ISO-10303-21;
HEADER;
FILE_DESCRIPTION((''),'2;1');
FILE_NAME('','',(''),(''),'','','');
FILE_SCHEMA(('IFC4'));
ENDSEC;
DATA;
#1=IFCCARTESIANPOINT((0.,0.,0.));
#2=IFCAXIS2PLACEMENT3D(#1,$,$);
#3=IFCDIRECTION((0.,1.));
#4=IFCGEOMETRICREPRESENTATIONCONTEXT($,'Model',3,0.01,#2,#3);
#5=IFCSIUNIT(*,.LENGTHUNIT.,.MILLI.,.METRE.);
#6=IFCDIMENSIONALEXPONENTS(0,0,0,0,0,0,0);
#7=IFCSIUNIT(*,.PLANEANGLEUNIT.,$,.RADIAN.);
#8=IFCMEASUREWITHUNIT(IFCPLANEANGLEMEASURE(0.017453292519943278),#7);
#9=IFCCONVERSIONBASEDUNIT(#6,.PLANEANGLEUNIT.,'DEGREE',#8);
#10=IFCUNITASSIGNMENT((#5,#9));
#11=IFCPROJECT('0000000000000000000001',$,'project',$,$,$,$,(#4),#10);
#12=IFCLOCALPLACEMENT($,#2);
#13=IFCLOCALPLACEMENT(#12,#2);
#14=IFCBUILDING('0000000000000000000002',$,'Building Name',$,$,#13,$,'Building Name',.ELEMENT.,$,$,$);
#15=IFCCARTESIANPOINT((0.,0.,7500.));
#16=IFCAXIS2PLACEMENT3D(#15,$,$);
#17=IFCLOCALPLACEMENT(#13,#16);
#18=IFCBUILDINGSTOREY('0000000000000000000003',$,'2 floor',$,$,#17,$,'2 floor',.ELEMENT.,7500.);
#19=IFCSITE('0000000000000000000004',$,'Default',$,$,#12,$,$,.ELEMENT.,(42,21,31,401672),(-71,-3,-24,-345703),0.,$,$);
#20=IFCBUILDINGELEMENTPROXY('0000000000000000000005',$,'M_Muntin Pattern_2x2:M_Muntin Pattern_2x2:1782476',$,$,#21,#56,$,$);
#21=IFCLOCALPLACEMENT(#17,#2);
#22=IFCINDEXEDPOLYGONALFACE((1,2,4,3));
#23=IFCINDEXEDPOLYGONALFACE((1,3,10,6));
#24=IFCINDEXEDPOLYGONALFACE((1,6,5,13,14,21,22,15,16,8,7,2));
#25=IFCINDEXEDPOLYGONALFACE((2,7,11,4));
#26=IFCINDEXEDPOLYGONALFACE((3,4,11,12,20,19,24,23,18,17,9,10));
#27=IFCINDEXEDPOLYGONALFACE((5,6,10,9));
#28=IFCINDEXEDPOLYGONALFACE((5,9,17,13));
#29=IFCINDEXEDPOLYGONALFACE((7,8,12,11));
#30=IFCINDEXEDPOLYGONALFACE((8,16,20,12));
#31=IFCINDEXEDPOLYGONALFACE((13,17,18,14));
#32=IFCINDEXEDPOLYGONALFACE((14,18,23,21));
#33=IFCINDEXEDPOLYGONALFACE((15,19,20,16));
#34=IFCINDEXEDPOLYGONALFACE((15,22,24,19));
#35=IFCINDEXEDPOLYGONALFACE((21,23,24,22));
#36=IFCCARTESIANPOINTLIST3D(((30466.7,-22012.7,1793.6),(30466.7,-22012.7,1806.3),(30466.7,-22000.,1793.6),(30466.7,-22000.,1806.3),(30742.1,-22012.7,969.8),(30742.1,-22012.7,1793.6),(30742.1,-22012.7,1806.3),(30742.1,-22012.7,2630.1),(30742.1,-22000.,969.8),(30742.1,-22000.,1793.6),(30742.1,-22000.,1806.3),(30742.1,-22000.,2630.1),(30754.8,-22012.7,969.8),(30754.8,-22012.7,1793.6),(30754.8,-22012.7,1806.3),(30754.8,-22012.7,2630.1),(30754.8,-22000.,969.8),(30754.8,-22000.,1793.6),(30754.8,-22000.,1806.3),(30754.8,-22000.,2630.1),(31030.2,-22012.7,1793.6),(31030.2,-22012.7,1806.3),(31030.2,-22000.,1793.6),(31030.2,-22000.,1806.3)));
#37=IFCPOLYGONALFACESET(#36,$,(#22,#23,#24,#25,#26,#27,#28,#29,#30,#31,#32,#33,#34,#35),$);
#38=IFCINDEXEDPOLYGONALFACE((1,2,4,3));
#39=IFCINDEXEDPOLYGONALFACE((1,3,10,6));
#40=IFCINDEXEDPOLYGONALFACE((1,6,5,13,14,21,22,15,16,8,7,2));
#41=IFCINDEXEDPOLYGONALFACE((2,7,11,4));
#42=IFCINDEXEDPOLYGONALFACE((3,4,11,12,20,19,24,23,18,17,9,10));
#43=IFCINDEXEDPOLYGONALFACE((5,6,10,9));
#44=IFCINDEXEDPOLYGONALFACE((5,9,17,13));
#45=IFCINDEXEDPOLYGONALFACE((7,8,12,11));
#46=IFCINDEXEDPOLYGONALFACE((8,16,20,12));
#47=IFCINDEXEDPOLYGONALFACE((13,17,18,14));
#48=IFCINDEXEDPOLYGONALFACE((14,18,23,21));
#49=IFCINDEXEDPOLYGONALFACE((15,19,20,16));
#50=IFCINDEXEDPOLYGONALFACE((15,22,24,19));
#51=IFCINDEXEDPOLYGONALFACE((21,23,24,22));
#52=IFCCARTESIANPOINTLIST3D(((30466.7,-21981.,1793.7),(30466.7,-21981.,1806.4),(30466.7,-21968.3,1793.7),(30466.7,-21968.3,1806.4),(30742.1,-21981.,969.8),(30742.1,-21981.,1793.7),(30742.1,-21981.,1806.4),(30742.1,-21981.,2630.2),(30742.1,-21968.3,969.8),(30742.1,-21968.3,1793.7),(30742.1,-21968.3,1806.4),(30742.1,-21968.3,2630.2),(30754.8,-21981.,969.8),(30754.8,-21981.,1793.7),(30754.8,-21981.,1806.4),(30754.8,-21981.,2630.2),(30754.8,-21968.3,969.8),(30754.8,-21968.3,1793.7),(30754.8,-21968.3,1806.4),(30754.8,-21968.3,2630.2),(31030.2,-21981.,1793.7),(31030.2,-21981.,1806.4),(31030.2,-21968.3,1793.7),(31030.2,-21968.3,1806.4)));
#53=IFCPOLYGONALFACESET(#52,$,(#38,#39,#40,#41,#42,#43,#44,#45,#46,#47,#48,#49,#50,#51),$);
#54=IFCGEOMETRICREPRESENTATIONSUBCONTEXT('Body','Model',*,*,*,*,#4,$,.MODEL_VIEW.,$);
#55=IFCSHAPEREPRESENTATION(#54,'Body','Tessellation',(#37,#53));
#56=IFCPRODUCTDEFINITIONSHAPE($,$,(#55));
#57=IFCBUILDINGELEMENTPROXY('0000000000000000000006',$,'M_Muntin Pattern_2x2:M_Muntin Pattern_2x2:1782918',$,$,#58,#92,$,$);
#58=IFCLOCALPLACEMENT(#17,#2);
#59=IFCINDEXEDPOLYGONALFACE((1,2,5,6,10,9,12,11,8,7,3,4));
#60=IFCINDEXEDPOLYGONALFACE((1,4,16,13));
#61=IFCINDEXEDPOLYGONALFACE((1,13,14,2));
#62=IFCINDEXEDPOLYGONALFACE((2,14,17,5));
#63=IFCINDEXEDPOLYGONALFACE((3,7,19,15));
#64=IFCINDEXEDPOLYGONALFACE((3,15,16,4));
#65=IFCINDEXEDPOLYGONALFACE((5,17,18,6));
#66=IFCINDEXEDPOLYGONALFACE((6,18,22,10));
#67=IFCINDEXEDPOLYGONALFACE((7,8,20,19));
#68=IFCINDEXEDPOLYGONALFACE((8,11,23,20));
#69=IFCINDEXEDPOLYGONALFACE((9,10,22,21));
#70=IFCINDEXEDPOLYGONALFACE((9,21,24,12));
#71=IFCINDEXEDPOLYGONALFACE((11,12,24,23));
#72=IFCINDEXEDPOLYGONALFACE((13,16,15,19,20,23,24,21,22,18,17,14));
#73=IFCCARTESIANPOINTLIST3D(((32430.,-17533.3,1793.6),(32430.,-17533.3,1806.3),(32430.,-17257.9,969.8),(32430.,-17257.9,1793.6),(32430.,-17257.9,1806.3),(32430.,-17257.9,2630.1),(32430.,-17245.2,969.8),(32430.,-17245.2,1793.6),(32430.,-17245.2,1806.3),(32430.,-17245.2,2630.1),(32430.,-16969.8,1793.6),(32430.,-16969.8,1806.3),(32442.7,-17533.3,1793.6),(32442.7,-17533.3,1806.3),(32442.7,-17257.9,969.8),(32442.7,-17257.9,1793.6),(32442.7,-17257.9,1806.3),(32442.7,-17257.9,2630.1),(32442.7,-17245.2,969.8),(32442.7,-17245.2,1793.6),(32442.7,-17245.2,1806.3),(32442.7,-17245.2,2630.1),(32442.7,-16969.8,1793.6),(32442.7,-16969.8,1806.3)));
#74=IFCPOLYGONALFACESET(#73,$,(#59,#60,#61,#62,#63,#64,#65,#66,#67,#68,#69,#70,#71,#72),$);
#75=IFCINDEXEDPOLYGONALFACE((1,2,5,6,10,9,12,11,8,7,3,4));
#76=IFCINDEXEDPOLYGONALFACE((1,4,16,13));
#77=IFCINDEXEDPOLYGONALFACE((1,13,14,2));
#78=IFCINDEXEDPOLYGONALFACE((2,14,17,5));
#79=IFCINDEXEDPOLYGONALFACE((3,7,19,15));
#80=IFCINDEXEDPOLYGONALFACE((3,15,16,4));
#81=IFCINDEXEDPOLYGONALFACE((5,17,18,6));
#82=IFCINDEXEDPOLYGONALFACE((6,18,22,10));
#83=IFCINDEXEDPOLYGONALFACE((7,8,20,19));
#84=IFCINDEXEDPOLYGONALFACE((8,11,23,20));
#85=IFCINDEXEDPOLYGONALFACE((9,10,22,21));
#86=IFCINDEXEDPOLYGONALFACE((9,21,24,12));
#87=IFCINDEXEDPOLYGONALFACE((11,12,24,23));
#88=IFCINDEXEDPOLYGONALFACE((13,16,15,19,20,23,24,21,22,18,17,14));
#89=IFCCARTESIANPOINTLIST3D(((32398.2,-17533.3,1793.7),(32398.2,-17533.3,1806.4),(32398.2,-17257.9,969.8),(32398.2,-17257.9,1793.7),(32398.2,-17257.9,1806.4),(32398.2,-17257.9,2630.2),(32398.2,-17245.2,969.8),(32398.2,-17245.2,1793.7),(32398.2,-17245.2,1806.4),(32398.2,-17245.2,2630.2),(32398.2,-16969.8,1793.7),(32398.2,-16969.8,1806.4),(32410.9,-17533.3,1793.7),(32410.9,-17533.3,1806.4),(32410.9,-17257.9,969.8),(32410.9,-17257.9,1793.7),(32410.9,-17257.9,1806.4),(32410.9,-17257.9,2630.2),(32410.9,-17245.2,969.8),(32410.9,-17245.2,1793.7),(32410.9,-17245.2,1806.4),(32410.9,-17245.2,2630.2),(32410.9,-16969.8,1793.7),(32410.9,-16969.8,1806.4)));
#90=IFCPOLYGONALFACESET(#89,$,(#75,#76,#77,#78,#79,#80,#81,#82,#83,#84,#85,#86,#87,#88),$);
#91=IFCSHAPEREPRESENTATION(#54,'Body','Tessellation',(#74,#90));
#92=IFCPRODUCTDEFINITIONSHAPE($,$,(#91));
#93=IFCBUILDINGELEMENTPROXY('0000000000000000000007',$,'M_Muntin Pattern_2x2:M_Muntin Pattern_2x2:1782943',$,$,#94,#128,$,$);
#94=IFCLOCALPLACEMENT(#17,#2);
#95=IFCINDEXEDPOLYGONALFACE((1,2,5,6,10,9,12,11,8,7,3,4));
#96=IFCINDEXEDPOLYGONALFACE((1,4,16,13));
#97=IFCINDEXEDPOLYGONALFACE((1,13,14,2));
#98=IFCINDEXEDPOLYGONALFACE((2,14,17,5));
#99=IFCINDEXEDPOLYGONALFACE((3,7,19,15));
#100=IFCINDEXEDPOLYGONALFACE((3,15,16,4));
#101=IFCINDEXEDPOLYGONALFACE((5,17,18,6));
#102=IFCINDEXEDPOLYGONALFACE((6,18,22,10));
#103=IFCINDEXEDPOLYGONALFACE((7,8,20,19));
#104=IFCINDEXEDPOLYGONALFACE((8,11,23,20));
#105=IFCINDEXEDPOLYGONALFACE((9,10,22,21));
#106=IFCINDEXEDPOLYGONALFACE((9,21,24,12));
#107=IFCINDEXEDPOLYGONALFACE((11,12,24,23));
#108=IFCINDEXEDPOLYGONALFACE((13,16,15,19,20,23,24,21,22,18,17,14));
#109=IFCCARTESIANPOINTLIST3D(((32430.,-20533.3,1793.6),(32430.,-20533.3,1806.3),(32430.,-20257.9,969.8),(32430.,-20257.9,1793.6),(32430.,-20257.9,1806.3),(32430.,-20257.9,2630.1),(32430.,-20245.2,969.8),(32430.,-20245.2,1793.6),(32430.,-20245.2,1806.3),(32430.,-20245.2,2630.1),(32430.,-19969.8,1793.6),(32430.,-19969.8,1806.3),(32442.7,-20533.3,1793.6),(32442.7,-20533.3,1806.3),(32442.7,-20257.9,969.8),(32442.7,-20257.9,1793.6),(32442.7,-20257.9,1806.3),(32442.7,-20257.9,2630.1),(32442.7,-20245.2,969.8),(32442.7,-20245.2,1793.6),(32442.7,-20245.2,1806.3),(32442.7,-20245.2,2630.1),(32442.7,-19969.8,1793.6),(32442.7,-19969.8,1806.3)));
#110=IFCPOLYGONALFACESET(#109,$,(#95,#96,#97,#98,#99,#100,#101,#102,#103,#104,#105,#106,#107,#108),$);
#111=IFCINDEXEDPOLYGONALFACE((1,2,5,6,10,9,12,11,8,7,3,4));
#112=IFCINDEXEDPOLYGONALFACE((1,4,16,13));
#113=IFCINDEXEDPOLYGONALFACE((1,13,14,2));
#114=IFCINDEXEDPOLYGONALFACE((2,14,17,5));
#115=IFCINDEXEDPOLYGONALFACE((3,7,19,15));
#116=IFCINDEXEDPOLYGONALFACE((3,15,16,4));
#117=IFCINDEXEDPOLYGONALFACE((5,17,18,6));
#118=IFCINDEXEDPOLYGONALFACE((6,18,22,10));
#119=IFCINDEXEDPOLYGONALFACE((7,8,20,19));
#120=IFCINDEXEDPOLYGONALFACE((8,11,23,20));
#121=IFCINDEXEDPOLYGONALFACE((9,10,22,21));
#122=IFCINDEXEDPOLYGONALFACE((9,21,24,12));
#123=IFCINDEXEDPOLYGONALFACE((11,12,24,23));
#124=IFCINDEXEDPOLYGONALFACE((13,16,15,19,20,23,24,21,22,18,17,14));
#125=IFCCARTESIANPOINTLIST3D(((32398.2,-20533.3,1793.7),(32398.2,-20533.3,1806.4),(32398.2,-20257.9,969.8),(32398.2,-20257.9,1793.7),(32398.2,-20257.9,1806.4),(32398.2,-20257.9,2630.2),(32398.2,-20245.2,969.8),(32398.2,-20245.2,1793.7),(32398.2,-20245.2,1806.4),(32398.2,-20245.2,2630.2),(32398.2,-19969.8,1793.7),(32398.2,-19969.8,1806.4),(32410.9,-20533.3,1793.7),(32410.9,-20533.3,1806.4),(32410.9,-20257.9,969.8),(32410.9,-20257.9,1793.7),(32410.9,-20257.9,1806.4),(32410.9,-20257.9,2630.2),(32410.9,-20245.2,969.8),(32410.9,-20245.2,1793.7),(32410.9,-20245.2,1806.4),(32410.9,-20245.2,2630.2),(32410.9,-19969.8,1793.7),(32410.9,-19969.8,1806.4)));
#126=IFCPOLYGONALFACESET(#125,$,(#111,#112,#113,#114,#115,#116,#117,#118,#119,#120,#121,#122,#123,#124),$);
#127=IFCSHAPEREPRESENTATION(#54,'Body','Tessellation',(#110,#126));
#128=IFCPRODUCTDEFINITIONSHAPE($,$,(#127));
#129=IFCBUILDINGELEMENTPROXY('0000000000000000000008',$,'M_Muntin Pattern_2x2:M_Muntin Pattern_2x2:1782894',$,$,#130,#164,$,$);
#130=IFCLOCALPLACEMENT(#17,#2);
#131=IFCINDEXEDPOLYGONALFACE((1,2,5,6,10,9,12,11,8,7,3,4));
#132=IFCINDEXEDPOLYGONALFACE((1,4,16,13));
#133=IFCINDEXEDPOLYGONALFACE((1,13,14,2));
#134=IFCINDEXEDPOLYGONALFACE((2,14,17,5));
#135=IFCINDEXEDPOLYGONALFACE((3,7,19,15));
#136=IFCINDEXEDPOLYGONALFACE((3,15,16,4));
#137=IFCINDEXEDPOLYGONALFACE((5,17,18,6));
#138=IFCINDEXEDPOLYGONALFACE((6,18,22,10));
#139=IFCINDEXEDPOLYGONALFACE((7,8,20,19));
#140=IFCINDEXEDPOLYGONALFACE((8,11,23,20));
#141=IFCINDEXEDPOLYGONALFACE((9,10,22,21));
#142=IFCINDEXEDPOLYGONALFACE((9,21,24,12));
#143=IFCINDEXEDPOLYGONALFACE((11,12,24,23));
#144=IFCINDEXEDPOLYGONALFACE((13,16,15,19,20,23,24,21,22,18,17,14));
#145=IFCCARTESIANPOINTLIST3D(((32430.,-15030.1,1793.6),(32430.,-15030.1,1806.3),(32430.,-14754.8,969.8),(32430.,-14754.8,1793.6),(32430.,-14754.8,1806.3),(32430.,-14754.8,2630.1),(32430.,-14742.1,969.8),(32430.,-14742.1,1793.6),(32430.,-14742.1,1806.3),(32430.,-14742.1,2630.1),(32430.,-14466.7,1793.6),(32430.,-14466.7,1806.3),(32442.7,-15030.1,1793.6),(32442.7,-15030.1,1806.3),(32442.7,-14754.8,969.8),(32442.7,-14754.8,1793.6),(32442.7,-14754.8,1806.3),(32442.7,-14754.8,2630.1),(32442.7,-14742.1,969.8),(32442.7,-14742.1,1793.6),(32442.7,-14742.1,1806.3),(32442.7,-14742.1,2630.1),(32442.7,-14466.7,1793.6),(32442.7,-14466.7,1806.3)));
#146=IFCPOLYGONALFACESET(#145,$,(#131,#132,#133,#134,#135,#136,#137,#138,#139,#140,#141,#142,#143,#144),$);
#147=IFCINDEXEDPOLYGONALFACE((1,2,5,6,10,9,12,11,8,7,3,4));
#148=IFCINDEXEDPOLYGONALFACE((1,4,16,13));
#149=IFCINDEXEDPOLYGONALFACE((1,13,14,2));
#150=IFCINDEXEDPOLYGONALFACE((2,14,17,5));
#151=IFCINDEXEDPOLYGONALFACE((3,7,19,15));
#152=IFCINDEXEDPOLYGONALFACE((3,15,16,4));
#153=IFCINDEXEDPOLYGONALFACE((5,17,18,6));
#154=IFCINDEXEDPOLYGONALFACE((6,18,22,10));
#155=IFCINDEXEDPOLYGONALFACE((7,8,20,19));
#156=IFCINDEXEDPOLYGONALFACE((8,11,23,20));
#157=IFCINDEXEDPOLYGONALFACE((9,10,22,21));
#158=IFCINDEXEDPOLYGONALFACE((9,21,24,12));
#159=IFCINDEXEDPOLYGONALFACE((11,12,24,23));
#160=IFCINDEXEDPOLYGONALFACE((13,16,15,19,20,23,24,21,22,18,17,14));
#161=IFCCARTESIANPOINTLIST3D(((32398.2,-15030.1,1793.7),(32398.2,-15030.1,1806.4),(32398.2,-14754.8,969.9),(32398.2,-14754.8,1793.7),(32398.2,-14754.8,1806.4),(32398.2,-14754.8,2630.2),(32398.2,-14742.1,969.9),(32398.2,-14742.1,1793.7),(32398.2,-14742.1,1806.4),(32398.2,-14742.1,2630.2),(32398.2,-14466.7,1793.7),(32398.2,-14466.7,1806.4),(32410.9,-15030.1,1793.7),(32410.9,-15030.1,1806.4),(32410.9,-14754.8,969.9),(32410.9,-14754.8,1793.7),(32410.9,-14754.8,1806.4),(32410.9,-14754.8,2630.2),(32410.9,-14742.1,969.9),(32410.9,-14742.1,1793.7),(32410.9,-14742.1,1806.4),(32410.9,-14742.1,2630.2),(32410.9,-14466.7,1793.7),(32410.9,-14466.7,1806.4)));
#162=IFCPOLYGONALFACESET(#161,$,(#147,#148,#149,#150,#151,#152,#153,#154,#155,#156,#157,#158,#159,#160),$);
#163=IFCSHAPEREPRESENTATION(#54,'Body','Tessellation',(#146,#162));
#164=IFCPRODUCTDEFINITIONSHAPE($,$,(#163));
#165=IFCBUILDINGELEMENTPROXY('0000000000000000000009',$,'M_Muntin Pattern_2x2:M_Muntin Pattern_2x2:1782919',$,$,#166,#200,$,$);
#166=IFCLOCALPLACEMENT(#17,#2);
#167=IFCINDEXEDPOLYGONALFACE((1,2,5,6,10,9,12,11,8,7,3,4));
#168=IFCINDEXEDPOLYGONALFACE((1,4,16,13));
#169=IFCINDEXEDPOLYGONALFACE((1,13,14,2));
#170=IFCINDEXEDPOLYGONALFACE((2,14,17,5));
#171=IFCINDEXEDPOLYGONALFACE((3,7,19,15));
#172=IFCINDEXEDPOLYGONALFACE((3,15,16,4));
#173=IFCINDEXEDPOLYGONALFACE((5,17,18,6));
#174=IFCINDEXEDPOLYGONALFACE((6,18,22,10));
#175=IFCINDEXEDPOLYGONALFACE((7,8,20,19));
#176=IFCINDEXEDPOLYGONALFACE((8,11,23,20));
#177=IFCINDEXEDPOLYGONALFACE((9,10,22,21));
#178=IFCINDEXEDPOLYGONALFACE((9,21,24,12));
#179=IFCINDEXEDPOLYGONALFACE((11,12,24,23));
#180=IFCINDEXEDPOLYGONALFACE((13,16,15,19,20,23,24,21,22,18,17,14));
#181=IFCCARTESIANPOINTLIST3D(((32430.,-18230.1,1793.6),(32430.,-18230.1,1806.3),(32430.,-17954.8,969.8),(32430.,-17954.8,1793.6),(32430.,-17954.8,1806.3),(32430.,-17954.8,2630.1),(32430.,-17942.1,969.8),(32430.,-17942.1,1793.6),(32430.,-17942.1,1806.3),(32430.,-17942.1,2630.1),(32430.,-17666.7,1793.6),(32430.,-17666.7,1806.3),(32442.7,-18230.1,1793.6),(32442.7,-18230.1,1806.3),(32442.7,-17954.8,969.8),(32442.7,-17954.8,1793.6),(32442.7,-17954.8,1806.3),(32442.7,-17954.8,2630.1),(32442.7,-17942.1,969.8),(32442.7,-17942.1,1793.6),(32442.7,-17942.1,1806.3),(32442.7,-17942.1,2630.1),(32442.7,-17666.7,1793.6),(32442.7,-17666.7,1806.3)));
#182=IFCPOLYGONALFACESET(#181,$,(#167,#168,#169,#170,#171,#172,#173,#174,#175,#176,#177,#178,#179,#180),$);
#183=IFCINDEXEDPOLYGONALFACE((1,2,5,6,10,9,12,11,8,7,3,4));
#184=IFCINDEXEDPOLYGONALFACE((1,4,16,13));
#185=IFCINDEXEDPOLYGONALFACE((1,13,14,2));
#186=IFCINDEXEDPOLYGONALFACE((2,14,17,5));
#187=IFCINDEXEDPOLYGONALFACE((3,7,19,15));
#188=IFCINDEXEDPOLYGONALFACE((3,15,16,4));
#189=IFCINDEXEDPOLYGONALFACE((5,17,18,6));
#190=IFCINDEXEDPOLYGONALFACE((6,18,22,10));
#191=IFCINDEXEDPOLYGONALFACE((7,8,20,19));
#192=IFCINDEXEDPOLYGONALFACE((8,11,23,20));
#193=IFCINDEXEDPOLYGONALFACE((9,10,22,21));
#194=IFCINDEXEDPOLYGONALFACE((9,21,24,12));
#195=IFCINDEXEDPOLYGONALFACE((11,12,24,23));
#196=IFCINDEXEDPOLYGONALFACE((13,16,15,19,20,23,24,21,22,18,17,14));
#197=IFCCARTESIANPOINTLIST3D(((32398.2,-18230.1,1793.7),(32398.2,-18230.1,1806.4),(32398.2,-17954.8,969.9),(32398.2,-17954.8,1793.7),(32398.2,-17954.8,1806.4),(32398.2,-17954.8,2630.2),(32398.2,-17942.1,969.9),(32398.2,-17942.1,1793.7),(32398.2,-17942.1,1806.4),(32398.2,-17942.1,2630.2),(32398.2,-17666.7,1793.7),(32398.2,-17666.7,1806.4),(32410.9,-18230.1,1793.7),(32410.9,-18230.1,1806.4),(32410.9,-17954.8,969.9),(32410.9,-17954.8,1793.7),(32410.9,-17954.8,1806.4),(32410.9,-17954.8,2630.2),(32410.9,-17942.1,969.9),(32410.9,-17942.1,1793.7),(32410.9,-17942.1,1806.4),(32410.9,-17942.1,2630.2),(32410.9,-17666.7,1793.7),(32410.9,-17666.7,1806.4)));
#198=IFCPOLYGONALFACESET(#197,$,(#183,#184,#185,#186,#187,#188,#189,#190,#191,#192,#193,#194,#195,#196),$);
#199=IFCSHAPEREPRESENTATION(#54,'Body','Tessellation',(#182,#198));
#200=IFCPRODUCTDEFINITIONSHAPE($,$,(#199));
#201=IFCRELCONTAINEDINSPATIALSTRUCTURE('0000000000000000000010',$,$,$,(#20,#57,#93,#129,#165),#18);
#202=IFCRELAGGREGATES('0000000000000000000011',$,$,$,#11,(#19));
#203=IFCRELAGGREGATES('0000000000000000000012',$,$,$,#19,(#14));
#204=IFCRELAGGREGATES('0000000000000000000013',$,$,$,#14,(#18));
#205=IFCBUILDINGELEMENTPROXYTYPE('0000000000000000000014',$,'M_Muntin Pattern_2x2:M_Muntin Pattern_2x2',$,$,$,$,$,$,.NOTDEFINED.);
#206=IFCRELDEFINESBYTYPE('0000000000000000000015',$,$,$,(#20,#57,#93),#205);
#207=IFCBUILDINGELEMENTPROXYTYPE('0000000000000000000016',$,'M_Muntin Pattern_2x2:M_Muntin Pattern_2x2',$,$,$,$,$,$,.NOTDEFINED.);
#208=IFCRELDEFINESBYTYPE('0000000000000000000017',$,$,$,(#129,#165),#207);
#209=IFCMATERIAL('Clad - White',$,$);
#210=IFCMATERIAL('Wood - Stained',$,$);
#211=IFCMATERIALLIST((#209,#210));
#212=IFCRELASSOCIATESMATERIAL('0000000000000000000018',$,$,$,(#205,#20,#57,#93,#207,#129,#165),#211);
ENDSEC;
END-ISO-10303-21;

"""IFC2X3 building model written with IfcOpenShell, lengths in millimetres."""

from ifc_helpers import new_model, entity, si_unit, converted_unit, direction, frame, origin, place, context, subcontext, project, spatial, polyline, outline, extrude, source, transform, mapped, material, material_list, type_object, type_shapes, element, save


model = new_model("IFC2X3")

# Units and contexts
model_context = context("Model", 3, precision=0.01, world=origin(), true_north=direction((0.0, 1.0)))
body_context = subcontext(model_context, "Body", "Model", "MODEL_VIEW")
ifc_project = project(units=[si_unit("LENGTHUNIT", "METRE", prefix="MILLI"), converted_unit("PLANEANGLEUNIT", "DEGREE", entity("IfcPlaneAngleMeasure", 0.017453292519943278), si_unit("PLANEANGLEUNIT", "RADIAN"), dimensions=[0, 0, 0, 0, 0, 0, 0])], contexts=[model_context])

# Site, building, storey
site_placement = place(None, origin())
site = spatial("IfcSite", under=ifc_project, at=site_placement, Name="Default", CompositionType="ELEMENT", RefLatitude=(42, 21, 31, 401672), RefLongitude=(-71, -3, -24, -345703), RefElevation=0.0)
building_placement = place(site_placement, origin())
building = spatial("IfcBuilding", under=site, at=building_placement, Name="Building Name", LongName="Building Name", CompositionType="ELEMENT")
storey_placement = place(building_placement, frame((0.0, 0.0, 7500.0)))
storey = spatial("IfcBuildingStorey", under=building, at=storey_placement, Name="2 floor", LongName="2 floor", CompositionType="ELEMENT", Elevation=7500.0)

# Building element proxies
ifc_material_1 = material(Name="Clad - White")
ifc_material_2 = material(Name="Wood - Stained")
ifc_material_list = material_list([ifc_material_1, ifc_material_2])
building_element_proxy_type_1 = type_object("IfcBuildingElementProxyType", Name="M_Muntin Pattern_2x2:M_Muntin Pattern_2x2", PredefinedType="NOTDEFINED", material=ifc_material_list)
shared_shape_1 = source(origin(), body_context, "Body", "SweptSolid", [
    extrude(outline(polyline([(6.4, -6.4), (830.1, -6.4), (830.1, 6.3), (6.4, 6.3), (6.4, 281.7), (-6.3, 281.7), (-6.3, 6.3), (-830.2, 6.3), (-830.2, -6.4), (-6.3, -6.4), (-6.3, -281.7), (6.4, -281.7), (6.4, -6.4)])), frame((0.0, 9.5, 830.1), z_axis=(0.0, 1.0, 0.0), x_axis=(0.0, 0.0, 1.0)), (0.0, 0.0, 1.0), 12.7),
    extrude(outline(polyline([(6.4, -6.4), (830.2, -6.4), (830.2, 6.3), (6.4, 6.3), (6.4, 281.7), (-6.3, 281.7), (-6.3, 6.3), (-830.2, 6.3), (-830.2, -6.4), (-6.3, -6.4), (-6.3, -281.7), (6.4, -281.7), (6.4, -6.4)])), frame((0.0, -22.2, 830.2), z_axis=(0.0, 1.0, 0.0), x_axis=(0.0, 0.0, 1.0)), (0.0, 0.0, 1.0), 12.7),
])
type_shapes(building_element_proxy_type_1, [shared_shape_1])
for number, where, z_axis, x_axis, name in (
    (1, (30748.4, -21990.5, 969.8), (0.0, 0.0, 1.0), (-1.0, 0.0, 0.0), "M_Muntin Pattern_2x2:M_Muntin Pattern_2x2:1782476"),
    (2, (32420.5, -17251.6, 969.8), (0.0, 0.0, 1.0), (0.0, -1.0, 0.0), "M_Muntin Pattern_2x2:M_Muntin Pattern_2x2:1782918"),
    (3, (32420.5, -20251.6, 969.8), (0.0, 0.0, 1.0), (0.0, -1.0, 0.0), "M_Muntin Pattern_2x2:M_Muntin Pattern_2x2:1782943"),
):
    element("IfcBuildingElementProxy", number, at=place(storey_placement, frame(where, z_axis=z_axis, x_axis=x_axis)), inside=storey, type_object=building_element_proxy_type_1, material=ifc_material_list, Name=name, context=body_context, shape_type="MappedRepresentation", body=[
        mapped(shared_shape_1, transform((0.0, 0.0, 0.0), scale=1.0)),
    ])
building_element_proxy_type_2 = type_object("IfcBuildingElementProxyType", Name="M_Muntin Pattern_2x2:M_Muntin Pattern_2x2", PredefinedType="NOTDEFINED", material=ifc_material_list)
shared_shape_2 = source(origin(), body_context, "Body", "SweptSolid", [
    extrude(outline(polyline([(6.4, -6.4), (830.1, -6.4), (830.1, 6.3), (6.4, 6.3), (6.4, 281.7), (-6.3, 281.7), (-6.3, 6.3), (-830.2, 6.3), (-830.2, -6.4), (-6.3, -6.4), (-6.3, -281.7), (6.4, -281.7), (6.4, -6.4)])), frame((0.0, -22.2, 830.1), z_axis=(0.0, 1.0, 0.0), x_axis=(0.0, 0.0, 1.0)), (0.0, 0.0, 1.0), 12.7),
    extrude(outline(polyline([(6.4, -6.4), (830.2, -6.4), (830.2, 6.3), (6.4, 6.3), (6.4, 281.7), (-6.3, 281.7), (-6.3, 6.3), (-830.2, 6.3), (-830.2, -6.4), (-6.3, -6.4), (-6.3, -281.7), (6.4, -281.7), (6.4, -6.4)])), frame((0.0, 9.5, 830.2), z_axis=(0.0, 1.0, 0.0), x_axis=(0.0, 0.0, 1.0)), (0.0, 0.0, 1.0), 12.7),
])
type_shapes(building_element_proxy_type_2, [shared_shape_2])
for number, where, z_axis, x_axis, name in (
    (4, (32420.5, -14748.4, 969.9), (0.0, 0.0, 1.0), (0.0, 1.0, 0.0), "M_Muntin Pattern_2x2:M_Muntin Pattern_2x2:1782894"),
    (5, (32420.5, -17948.4, 969.9), (0.0, 0.0, 1.0), (0.0, 1.0, 0.0), "M_Muntin Pattern_2x2:M_Muntin Pattern_2x2:1782919"),
):
    element("IfcBuildingElementProxy", number, at=place(storey_placement, frame(where, z_axis=z_axis, x_axis=x_axis)), inside=storey, type_object=building_element_proxy_type_2, material=ifc_material_list, Name=name, context=body_context, shape_type="MappedRepresentation", body=[
        mapped(shared_shape_2, transform((0.0, 0.0, 0.0), scale=1.0)),
    ])

save(model, "model.ifc")
